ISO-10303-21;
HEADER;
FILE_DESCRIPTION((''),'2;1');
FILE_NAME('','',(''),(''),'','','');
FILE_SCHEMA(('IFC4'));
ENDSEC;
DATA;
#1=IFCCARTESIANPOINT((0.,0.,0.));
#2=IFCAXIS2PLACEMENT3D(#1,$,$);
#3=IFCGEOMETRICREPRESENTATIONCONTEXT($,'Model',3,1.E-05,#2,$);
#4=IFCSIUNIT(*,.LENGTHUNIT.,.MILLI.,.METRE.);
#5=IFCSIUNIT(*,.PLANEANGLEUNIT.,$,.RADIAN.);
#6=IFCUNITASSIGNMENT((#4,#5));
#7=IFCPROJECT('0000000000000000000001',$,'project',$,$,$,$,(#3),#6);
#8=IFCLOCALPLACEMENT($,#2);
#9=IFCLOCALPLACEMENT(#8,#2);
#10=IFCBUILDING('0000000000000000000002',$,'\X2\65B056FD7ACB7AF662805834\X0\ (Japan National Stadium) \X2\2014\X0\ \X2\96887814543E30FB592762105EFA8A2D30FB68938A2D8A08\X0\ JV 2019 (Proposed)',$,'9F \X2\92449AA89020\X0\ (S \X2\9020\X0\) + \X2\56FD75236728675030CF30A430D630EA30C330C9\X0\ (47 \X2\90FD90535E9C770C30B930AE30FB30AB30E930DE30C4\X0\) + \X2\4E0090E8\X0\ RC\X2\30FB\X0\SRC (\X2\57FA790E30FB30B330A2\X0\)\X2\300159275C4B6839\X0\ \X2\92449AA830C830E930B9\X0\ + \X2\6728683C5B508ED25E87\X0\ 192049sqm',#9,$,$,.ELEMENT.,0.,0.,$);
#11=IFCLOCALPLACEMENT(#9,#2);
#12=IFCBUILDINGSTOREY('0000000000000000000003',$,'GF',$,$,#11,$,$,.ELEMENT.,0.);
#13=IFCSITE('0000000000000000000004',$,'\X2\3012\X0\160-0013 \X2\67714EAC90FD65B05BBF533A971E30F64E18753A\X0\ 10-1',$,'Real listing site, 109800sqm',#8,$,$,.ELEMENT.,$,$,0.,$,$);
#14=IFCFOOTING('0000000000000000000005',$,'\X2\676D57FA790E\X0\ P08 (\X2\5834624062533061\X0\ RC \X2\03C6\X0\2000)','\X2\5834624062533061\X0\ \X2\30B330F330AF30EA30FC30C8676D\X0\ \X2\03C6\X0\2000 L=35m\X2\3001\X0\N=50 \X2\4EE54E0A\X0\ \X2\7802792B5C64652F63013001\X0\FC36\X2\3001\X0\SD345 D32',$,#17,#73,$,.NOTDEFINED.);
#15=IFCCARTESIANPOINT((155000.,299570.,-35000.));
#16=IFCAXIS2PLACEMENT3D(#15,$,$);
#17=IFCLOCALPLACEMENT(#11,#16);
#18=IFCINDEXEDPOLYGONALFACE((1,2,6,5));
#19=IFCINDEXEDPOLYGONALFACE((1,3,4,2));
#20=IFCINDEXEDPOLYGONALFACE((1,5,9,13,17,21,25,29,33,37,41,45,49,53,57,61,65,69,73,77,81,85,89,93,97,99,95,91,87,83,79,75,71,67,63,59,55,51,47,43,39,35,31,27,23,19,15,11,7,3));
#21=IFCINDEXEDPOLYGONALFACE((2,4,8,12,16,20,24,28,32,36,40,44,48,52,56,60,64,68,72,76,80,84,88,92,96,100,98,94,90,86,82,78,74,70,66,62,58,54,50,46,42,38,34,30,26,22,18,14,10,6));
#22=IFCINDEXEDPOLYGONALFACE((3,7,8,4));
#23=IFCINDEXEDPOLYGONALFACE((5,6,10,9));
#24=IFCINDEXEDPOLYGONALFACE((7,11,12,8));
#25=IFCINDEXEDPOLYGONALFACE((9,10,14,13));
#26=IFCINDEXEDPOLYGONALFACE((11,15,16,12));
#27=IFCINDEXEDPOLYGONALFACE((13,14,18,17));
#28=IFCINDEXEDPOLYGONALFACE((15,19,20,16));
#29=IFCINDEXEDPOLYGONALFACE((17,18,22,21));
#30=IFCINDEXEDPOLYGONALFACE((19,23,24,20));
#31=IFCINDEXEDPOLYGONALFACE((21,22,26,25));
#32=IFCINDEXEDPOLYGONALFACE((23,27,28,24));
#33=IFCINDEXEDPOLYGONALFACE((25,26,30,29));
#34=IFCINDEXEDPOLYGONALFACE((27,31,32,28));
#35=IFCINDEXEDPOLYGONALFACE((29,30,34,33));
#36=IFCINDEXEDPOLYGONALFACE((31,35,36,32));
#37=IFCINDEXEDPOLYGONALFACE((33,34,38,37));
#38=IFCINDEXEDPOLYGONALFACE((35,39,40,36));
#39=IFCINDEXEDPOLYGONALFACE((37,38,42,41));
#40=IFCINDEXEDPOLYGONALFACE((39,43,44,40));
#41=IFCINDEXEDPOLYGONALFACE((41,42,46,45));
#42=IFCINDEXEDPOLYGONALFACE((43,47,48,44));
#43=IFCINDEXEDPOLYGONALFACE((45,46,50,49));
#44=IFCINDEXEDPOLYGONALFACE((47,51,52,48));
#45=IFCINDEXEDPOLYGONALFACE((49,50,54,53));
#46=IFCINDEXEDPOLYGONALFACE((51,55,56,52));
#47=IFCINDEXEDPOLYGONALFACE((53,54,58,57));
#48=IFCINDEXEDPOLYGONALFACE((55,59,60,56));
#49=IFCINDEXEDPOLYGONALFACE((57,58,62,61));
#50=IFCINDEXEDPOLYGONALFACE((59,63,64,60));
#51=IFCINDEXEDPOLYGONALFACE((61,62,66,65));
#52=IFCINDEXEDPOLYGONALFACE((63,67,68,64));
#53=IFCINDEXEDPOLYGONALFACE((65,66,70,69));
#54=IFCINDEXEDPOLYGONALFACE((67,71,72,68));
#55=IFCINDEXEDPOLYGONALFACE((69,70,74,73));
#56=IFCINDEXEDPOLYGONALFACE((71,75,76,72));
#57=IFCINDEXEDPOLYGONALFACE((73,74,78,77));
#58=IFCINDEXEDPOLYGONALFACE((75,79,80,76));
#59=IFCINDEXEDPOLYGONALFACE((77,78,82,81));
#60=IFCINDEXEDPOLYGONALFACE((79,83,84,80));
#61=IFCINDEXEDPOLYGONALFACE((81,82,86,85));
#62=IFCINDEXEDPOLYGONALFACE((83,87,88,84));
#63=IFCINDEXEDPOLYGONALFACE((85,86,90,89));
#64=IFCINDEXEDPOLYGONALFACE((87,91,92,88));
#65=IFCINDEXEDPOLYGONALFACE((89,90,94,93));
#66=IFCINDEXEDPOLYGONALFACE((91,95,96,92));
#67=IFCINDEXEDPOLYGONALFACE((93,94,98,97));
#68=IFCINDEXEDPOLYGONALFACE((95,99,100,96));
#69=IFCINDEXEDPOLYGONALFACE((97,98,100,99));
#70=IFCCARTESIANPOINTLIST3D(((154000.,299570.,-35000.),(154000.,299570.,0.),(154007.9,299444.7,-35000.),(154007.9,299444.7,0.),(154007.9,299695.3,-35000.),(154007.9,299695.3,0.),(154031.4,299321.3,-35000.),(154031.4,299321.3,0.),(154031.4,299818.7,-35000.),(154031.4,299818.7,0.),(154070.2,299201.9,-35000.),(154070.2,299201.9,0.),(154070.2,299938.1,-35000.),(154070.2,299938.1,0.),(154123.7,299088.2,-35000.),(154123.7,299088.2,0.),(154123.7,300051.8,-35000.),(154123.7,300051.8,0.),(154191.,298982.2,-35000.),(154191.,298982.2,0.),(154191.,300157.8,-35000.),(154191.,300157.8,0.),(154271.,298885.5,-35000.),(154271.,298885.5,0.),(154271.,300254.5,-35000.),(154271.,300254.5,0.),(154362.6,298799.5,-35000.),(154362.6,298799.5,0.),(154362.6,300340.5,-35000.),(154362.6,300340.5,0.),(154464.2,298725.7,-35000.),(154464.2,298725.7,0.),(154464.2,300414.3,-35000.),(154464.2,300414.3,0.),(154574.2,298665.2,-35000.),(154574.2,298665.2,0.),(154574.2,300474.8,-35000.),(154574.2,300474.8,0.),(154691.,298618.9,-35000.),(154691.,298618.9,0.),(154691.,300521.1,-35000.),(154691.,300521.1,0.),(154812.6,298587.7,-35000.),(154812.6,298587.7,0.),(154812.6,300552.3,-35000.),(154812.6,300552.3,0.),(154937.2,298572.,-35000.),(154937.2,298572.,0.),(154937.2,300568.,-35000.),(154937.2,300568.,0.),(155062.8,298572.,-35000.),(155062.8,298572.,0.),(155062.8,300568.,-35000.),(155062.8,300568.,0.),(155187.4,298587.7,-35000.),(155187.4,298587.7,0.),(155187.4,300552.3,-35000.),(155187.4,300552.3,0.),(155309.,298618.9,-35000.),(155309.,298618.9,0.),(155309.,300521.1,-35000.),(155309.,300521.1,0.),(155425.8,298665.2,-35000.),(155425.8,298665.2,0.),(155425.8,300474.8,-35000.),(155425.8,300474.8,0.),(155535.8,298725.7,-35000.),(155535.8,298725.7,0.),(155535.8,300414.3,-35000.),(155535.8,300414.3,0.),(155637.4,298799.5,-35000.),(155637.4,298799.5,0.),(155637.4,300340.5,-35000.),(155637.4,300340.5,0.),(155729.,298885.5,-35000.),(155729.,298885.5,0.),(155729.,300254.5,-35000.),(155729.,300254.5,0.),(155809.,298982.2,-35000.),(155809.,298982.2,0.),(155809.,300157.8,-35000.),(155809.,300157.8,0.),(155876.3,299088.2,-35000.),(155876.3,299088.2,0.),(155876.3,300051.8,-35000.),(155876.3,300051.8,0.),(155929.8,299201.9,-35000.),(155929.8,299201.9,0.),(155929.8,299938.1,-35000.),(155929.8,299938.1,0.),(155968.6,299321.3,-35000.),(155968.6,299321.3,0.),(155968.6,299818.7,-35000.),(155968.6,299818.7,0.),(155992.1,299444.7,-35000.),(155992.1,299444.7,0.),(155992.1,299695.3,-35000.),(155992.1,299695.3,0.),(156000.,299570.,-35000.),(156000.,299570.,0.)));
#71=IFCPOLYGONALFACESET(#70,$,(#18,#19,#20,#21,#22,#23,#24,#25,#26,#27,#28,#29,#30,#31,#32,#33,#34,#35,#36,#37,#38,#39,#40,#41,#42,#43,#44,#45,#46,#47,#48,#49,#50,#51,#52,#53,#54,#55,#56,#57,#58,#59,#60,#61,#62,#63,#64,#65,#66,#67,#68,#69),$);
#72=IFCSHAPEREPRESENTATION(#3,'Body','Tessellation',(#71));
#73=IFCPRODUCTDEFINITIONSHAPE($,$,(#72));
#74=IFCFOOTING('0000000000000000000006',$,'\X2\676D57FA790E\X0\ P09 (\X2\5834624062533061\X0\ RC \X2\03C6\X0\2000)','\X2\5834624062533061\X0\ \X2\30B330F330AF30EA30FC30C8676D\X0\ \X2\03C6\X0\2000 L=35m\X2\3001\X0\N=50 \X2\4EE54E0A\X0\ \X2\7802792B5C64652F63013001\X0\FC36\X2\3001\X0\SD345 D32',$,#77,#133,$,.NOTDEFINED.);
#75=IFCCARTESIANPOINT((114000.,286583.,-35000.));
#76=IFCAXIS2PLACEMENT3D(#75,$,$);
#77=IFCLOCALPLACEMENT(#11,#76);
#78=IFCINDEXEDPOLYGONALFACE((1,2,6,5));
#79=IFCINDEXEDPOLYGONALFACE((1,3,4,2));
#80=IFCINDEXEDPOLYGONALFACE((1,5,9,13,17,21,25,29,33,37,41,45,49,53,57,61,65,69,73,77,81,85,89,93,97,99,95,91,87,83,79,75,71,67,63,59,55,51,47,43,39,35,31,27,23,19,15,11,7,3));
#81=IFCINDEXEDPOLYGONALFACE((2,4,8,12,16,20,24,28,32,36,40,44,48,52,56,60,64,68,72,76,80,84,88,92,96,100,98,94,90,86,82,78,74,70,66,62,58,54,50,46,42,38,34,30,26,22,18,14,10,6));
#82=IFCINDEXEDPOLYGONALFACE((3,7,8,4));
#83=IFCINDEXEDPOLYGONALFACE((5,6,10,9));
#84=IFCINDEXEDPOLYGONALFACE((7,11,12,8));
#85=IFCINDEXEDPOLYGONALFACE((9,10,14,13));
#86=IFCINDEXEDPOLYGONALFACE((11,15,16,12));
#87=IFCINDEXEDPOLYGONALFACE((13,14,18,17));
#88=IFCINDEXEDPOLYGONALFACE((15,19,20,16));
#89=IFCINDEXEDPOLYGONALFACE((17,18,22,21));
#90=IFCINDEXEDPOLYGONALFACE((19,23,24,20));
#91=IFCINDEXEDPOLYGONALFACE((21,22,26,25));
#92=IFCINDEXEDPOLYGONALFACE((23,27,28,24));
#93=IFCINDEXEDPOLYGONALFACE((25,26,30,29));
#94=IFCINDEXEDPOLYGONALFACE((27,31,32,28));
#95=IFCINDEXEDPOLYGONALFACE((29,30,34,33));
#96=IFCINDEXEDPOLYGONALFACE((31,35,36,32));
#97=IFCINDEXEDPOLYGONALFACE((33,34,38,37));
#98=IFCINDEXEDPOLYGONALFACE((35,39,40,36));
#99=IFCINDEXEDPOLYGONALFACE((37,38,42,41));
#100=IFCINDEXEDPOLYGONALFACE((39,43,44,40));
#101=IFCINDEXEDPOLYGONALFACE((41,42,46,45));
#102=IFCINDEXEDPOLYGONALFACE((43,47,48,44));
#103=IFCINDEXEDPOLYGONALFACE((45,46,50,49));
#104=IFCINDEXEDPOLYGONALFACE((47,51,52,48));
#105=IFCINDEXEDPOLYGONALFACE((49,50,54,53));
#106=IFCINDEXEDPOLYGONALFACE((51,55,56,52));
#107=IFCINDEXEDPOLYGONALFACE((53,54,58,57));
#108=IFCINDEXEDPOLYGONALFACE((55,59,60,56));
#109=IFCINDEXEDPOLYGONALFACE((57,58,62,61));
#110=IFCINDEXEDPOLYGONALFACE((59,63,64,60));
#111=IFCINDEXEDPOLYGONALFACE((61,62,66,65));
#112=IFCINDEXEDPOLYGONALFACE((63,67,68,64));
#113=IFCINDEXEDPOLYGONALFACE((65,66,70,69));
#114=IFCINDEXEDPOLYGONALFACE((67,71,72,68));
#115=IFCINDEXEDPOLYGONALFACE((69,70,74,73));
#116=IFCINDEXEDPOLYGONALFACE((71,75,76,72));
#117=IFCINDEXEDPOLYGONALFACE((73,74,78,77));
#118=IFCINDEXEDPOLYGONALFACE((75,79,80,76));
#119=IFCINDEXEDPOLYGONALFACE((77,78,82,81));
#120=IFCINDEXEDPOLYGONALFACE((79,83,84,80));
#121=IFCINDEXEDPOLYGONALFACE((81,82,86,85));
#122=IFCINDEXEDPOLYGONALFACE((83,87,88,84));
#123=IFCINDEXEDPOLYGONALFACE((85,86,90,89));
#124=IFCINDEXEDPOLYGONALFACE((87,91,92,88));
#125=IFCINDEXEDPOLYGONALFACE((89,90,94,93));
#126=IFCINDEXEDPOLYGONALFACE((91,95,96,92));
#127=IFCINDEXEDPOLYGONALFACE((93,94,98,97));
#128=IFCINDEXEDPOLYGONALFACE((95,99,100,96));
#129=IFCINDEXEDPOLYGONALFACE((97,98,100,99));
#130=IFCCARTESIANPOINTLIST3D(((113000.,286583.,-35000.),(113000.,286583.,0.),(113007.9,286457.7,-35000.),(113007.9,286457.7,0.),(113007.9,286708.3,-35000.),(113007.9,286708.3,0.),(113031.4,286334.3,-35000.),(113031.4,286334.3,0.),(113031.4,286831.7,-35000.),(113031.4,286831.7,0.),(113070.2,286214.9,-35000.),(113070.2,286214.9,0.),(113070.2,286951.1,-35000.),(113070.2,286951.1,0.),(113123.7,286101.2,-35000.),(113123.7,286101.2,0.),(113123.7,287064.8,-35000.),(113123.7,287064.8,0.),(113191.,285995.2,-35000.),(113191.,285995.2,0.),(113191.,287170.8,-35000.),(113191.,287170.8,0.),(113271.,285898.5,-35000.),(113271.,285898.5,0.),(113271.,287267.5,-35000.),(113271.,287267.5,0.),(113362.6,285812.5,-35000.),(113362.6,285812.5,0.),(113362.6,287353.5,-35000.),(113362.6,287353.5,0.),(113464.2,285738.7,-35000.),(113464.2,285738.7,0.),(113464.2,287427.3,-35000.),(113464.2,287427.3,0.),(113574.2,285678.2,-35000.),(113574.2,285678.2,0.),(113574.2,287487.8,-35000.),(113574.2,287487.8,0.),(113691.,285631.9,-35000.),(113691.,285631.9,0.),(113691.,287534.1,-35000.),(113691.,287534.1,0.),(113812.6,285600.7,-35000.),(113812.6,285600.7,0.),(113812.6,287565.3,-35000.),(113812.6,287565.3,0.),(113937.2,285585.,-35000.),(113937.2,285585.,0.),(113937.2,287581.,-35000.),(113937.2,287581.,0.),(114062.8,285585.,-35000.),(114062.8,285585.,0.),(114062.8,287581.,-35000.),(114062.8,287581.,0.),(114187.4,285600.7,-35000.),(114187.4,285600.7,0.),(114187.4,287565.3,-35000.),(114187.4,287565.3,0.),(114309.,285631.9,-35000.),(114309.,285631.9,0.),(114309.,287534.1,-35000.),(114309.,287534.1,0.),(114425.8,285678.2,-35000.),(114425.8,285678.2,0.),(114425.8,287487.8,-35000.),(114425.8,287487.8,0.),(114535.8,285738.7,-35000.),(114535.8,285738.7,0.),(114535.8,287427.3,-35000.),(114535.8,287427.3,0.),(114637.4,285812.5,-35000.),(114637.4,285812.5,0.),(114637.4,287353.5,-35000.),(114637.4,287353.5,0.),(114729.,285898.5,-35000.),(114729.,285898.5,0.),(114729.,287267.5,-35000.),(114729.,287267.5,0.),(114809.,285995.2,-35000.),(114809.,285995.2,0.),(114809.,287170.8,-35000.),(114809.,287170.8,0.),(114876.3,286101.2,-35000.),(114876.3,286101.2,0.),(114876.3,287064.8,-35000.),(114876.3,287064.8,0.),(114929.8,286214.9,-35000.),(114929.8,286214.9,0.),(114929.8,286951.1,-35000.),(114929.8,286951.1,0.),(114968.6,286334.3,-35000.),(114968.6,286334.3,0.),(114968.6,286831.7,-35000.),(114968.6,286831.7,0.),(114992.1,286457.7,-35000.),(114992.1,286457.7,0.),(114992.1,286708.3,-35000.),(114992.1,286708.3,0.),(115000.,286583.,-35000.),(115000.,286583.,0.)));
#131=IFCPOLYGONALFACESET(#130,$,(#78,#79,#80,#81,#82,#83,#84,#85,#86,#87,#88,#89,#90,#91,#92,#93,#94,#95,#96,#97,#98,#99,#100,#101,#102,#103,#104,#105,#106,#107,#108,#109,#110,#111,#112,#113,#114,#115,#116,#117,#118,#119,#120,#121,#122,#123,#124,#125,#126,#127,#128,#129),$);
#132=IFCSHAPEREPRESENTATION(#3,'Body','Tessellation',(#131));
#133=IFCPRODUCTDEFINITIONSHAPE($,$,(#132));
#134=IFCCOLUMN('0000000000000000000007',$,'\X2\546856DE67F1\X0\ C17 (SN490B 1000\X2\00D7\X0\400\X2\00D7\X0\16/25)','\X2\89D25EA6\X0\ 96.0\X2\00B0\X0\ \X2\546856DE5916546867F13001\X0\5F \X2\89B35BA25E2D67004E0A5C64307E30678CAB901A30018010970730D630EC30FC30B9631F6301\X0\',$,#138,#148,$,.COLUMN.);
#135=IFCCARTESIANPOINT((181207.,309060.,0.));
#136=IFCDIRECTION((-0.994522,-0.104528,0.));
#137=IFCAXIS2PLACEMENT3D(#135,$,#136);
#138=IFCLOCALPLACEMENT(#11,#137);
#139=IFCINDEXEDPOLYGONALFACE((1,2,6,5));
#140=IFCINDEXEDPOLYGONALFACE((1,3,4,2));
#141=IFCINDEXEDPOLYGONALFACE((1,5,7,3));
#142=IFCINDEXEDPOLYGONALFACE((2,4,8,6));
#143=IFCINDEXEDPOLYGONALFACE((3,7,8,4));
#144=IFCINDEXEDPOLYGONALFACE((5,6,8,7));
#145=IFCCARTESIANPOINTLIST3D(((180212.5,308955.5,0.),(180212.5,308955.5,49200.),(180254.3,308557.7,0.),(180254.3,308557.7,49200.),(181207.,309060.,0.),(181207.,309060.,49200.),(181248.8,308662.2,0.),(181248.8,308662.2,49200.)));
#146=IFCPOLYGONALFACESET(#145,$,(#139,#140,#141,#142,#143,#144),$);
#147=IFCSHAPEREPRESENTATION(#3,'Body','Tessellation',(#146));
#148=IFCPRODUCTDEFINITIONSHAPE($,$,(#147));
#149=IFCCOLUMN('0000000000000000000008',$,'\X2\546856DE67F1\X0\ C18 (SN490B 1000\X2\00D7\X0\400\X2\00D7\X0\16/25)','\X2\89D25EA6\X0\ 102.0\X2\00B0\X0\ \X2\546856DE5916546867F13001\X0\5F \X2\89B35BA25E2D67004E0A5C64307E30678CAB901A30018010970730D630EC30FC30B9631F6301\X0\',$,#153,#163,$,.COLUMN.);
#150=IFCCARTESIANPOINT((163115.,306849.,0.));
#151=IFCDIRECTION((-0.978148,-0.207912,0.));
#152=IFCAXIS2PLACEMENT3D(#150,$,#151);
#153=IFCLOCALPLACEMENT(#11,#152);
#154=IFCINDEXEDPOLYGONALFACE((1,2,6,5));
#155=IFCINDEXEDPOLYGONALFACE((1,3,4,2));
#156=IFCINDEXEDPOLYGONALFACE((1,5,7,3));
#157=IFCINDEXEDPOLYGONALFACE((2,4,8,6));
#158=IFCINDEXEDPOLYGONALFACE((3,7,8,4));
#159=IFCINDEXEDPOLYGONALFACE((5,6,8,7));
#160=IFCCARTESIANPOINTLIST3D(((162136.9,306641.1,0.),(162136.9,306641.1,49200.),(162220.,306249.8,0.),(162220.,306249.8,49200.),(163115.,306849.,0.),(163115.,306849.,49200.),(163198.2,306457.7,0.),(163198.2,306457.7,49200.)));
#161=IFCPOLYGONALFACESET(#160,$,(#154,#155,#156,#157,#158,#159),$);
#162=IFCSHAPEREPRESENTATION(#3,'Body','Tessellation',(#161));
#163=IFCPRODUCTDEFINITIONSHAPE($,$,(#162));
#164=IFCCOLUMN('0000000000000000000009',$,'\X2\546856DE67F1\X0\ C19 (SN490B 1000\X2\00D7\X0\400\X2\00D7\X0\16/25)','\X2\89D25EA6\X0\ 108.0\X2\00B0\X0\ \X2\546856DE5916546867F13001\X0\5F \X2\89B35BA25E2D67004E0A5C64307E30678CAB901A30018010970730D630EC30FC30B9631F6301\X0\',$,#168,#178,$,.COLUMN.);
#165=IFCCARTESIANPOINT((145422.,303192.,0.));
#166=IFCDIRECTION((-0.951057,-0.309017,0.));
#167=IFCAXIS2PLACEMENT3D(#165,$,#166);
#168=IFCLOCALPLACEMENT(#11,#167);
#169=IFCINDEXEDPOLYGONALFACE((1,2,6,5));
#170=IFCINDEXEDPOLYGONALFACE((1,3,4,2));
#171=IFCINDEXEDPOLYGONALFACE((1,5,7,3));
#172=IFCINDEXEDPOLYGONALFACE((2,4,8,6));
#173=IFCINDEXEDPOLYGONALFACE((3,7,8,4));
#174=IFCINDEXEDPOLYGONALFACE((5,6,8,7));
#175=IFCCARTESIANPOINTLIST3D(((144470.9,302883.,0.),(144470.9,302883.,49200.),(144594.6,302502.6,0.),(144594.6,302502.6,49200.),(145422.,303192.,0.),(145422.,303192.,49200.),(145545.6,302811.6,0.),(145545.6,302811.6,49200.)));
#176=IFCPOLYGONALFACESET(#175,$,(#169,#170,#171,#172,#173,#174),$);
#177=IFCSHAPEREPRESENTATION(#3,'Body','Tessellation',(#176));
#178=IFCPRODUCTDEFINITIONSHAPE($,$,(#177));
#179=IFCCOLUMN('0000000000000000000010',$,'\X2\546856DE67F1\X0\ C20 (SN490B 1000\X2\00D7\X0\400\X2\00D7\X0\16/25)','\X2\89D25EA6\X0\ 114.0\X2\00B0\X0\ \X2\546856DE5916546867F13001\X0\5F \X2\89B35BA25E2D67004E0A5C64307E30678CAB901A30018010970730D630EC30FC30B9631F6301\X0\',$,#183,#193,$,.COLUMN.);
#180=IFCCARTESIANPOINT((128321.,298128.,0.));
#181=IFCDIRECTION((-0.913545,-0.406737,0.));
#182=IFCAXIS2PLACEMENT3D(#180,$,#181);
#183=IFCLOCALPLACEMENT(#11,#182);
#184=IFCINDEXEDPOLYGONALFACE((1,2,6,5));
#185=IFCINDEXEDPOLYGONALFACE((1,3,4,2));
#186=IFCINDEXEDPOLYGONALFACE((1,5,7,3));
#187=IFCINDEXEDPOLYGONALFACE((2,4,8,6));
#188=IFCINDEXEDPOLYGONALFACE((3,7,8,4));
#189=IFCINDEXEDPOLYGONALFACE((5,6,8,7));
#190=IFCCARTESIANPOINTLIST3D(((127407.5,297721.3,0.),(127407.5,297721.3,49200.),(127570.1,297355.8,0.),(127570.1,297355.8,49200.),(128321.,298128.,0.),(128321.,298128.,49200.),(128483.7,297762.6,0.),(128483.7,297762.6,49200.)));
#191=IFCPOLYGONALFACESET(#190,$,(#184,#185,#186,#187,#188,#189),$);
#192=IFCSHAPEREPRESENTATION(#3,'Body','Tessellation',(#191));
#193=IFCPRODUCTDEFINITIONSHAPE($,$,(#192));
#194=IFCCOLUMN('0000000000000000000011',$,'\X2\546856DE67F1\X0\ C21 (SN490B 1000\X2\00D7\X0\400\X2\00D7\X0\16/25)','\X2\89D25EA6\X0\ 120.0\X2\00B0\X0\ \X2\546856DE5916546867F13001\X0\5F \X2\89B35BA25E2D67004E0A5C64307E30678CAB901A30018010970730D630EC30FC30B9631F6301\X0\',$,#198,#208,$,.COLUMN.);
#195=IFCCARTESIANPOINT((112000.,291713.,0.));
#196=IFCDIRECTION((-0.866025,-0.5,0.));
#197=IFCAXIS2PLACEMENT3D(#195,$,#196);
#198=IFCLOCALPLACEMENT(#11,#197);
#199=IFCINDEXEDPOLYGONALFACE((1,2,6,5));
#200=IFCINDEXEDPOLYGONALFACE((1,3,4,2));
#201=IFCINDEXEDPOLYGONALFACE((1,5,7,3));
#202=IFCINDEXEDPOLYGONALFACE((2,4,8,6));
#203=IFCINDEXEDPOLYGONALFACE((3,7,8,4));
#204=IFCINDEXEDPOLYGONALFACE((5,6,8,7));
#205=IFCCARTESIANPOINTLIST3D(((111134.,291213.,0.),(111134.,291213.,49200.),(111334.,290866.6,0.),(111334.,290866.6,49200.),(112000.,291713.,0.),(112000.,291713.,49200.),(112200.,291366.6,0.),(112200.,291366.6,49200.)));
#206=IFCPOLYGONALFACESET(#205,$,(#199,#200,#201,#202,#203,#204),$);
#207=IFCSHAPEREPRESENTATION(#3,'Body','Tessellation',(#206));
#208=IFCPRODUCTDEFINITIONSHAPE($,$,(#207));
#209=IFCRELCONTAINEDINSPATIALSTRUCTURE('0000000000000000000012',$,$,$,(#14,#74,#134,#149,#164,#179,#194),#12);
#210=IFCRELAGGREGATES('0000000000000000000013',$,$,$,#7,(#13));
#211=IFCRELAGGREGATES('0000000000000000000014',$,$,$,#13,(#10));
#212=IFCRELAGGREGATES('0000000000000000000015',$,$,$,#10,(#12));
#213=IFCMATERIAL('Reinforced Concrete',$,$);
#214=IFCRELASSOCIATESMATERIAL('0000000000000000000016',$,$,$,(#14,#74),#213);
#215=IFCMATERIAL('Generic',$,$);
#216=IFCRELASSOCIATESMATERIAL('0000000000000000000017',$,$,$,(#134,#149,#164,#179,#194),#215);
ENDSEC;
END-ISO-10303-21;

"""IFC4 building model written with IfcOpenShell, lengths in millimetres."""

from ifc_helpers import new_model, si_unit, frame, frame_2d, origin, origin_2d, place, context, project, spatial, rectangle, circle, extrude, material, element, save


model = new_model("IFC4")

# Units and contexts
model_context = context("Model", 3, precision=1e-05, world=origin())
ifc_project = project(units=[si_unit("LENGTHUNIT", "METRE", prefix="MILLI"), si_unit("PLANEANGLEUNIT", "RADIAN")], contexts=[model_context])

# Site, building, storey
site_placement = place(None, origin())
site = spatial("IfcSite", under=ifc_project, at=site_placement, Name="〒160-0013 東京都新宿区霞ヶ丘町 10-1", ObjectType="Real listing site, 109800sqm", CompositionType="ELEMENT", RefElevation=0.0)
building_placement = place(site_placement, origin())
building = spatial("IfcBuilding", under=site, at=building_placement, Name="新国立競技場 (Japan National Stadium) — 隈研吾・大成建設・梓設計 JV 2019 (Proposed)", ObjectType="9F 鉄骨造 (S 造) + 国産木材ハイブリッド (47 都道府県スギ・カラマツ) + 一部 RC・SRC (基礎・コア)、大屋根 鉄骨トラス + 木格子軒庇 192049sqm", CompositionType="ELEMENT", ElevationOfRefHeight=0.0, ElevationOfTerrain=0.0)
storey_placement = place(building_placement, origin())
storey = spatial("IfcBuildingStorey", under=building, at=storey_placement, Name="GF", CompositionType="ELEMENT", Elevation=0.0)

# Footings
ifc_material_1 = material(Name="Reinforced Concrete")
footing_1_placement = place(storey_placement, frame((155000.0, 299570.0, -35000.0)))
element("IfcFooting", 1, at=footing_1_placement, inside=storey, material=ifc_material_1, Name="杭基礎 P08 (場所打ち RC φ2000)", Description="場所打ち コンクリート杭 φ2000 L=35m、N=50 以上 砂礫層支持、FC36、SD345 D32", PredefinedType="NOTDEFINED", context=model_context, shape_type="SweptSolid", body=[
    extrude(circle(Radius=1000.0, at=origin_2d()), frame((155000.0, 299570.0, -35000.0)), (0.0, 0.0, 1.0), 35000.0),
])
footing_2_placement = place(storey_placement, frame((114000.0, 286583.0, -35000.0)))
element("IfcFooting", 2, at=footing_2_placement, inside=storey, material=ifc_material_1, Name="杭基礎 P09 (場所打ち RC φ2000)", Description="場所打ち コンクリート杭 φ2000 L=35m、N=50 以上 砂礫層支持、FC36、SD345 D32", PredefinedType="NOTDEFINED", context=model_context, shape_type="SweptSolid", body=[
    extrude(circle(Radius=1000.0, at=origin_2d()), frame((114000.0, 286583.0, -35000.0)), (0.0, 0.0, 1.0), 35000.0),
])

# Columns
ifc_material_2 = material(Name="Generic")
column_1_placement = place(storey_placement, frame((181207.0, 309060.0, 0.0), x_axis=(-0.994522, -0.104528, 0.0)))
element("IfcColumn", 3, at=column_1_placement, inside=storey, material=ifc_material_2, Name="周回柱 C17 (SN490B 1000×400×16/25)", Description="角度 96.0° 周回外周柱、5F 観客席最上層まで貫通、耐震ブレース挟持", PredefinedType="COLUMN", context=model_context, shape_type="SweptSolid", body=[
    extrude(rectangle(XDim=1000.0, YDim=400.0, at=frame_2d((500.0, 200.0))), frame((181207.0, 309060.0, 0.0), x_axis=(-0.994522, -0.104528, 0.0)), (0.0, 0.0, 1.0), 49200.0),
])
column_2_placement = place(storey_placement, frame((163115.0, 306849.0, 0.0), x_axis=(-0.978148, -0.207912, 0.0)))
element("IfcColumn", 4, at=column_2_placement, inside=storey, material=ifc_material_2, Name="周回柱 C18 (SN490B 1000×400×16/25)", Description="角度 102.0° 周回外周柱、5F 観客席最上層まで貫通、耐震ブレース挟持", PredefinedType="COLUMN", context=model_context, shape_type="SweptSolid", body=[
    extrude(rectangle(XDim=1000.0, YDim=400.0, at=frame_2d((500.0, 200.0))), frame((163115.0, 306849.0, 0.0), x_axis=(-0.978148, -0.207912, 0.0)), (0.0, 0.0, 1.0), 49200.0),
])
column_3_placement = place(storey_placement, frame((145422.0, 303192.0, 0.0), x_axis=(-0.951057, -0.309017, 0.0)))
element("IfcColumn", 5, at=column_3_placement, inside=storey, material=ifc_material_2, Name="周回柱 C19 (SN490B 1000×400×16/25)", Description="角度 108.0° 周回外周柱、5F 観客席最上層まで貫通、耐震ブレース挟持", PredefinedType="COLUMN", context=model_context, shape_type="SweptSolid", body=[
    extrude(rectangle(XDim=1000.0, YDim=400.0, at=frame_2d((500.0, 200.0))), frame((145422.0, 303192.0, 0.0), x_axis=(-0.951057, -0.309017, 0.0)), (0.0, 0.0, 1.0), 49200.0),
])
column_4_placement = place(storey_placement, frame((128321.0, 298128.0, 0.0), x_axis=(-0.913545, -0.406737, 0.0)))
element("IfcColumn", 6, at=column_4_placement, inside=storey, material=ifc_material_2, Name="周回柱 C20 (SN490B 1000×400×16/25)", Description="角度 114.0° 周回外周柱、5F 観客席最上層まで貫通、耐震ブレース挟持", PredefinedType="COLUMN", context=model_context, shape_type="SweptSolid", body=[
    extrude(rectangle(XDim=1000.0, YDim=400.0, at=frame_2d((500.0, 200.0))), frame((128321.0, 298128.0, 0.0), x_axis=(-0.913545, -0.406737, 0.0)), (0.0, 0.0, 1.0), 49200.0),
])
column_5_placement = place(storey_placement, frame((112000.0, 291713.0, 0.0), x_axis=(-0.866025, -0.5, 0.0)))
element("IfcColumn", 7, at=column_5_placement, inside=storey, material=ifc_material_2, Name="周回柱 C21 (SN490B 1000×400×16/25)", Description="角度 120.0° 周回外周柱、5F 観客席最上層まで貫通、耐震ブレース挟持", PredefinedType="COLUMN", context=model_context, shape_type="SweptSolid", body=[
    extrude(rectangle(XDim=1000.0, YDim=400.0, at=frame_2d((500.0, 200.0))), frame((112000.0, 291713.0, 0.0), x_axis=(-0.866025, -0.5, 0.0)), (0.0, 0.0, 1.0), 49200.0),
])

save(model, "model.ifc")
